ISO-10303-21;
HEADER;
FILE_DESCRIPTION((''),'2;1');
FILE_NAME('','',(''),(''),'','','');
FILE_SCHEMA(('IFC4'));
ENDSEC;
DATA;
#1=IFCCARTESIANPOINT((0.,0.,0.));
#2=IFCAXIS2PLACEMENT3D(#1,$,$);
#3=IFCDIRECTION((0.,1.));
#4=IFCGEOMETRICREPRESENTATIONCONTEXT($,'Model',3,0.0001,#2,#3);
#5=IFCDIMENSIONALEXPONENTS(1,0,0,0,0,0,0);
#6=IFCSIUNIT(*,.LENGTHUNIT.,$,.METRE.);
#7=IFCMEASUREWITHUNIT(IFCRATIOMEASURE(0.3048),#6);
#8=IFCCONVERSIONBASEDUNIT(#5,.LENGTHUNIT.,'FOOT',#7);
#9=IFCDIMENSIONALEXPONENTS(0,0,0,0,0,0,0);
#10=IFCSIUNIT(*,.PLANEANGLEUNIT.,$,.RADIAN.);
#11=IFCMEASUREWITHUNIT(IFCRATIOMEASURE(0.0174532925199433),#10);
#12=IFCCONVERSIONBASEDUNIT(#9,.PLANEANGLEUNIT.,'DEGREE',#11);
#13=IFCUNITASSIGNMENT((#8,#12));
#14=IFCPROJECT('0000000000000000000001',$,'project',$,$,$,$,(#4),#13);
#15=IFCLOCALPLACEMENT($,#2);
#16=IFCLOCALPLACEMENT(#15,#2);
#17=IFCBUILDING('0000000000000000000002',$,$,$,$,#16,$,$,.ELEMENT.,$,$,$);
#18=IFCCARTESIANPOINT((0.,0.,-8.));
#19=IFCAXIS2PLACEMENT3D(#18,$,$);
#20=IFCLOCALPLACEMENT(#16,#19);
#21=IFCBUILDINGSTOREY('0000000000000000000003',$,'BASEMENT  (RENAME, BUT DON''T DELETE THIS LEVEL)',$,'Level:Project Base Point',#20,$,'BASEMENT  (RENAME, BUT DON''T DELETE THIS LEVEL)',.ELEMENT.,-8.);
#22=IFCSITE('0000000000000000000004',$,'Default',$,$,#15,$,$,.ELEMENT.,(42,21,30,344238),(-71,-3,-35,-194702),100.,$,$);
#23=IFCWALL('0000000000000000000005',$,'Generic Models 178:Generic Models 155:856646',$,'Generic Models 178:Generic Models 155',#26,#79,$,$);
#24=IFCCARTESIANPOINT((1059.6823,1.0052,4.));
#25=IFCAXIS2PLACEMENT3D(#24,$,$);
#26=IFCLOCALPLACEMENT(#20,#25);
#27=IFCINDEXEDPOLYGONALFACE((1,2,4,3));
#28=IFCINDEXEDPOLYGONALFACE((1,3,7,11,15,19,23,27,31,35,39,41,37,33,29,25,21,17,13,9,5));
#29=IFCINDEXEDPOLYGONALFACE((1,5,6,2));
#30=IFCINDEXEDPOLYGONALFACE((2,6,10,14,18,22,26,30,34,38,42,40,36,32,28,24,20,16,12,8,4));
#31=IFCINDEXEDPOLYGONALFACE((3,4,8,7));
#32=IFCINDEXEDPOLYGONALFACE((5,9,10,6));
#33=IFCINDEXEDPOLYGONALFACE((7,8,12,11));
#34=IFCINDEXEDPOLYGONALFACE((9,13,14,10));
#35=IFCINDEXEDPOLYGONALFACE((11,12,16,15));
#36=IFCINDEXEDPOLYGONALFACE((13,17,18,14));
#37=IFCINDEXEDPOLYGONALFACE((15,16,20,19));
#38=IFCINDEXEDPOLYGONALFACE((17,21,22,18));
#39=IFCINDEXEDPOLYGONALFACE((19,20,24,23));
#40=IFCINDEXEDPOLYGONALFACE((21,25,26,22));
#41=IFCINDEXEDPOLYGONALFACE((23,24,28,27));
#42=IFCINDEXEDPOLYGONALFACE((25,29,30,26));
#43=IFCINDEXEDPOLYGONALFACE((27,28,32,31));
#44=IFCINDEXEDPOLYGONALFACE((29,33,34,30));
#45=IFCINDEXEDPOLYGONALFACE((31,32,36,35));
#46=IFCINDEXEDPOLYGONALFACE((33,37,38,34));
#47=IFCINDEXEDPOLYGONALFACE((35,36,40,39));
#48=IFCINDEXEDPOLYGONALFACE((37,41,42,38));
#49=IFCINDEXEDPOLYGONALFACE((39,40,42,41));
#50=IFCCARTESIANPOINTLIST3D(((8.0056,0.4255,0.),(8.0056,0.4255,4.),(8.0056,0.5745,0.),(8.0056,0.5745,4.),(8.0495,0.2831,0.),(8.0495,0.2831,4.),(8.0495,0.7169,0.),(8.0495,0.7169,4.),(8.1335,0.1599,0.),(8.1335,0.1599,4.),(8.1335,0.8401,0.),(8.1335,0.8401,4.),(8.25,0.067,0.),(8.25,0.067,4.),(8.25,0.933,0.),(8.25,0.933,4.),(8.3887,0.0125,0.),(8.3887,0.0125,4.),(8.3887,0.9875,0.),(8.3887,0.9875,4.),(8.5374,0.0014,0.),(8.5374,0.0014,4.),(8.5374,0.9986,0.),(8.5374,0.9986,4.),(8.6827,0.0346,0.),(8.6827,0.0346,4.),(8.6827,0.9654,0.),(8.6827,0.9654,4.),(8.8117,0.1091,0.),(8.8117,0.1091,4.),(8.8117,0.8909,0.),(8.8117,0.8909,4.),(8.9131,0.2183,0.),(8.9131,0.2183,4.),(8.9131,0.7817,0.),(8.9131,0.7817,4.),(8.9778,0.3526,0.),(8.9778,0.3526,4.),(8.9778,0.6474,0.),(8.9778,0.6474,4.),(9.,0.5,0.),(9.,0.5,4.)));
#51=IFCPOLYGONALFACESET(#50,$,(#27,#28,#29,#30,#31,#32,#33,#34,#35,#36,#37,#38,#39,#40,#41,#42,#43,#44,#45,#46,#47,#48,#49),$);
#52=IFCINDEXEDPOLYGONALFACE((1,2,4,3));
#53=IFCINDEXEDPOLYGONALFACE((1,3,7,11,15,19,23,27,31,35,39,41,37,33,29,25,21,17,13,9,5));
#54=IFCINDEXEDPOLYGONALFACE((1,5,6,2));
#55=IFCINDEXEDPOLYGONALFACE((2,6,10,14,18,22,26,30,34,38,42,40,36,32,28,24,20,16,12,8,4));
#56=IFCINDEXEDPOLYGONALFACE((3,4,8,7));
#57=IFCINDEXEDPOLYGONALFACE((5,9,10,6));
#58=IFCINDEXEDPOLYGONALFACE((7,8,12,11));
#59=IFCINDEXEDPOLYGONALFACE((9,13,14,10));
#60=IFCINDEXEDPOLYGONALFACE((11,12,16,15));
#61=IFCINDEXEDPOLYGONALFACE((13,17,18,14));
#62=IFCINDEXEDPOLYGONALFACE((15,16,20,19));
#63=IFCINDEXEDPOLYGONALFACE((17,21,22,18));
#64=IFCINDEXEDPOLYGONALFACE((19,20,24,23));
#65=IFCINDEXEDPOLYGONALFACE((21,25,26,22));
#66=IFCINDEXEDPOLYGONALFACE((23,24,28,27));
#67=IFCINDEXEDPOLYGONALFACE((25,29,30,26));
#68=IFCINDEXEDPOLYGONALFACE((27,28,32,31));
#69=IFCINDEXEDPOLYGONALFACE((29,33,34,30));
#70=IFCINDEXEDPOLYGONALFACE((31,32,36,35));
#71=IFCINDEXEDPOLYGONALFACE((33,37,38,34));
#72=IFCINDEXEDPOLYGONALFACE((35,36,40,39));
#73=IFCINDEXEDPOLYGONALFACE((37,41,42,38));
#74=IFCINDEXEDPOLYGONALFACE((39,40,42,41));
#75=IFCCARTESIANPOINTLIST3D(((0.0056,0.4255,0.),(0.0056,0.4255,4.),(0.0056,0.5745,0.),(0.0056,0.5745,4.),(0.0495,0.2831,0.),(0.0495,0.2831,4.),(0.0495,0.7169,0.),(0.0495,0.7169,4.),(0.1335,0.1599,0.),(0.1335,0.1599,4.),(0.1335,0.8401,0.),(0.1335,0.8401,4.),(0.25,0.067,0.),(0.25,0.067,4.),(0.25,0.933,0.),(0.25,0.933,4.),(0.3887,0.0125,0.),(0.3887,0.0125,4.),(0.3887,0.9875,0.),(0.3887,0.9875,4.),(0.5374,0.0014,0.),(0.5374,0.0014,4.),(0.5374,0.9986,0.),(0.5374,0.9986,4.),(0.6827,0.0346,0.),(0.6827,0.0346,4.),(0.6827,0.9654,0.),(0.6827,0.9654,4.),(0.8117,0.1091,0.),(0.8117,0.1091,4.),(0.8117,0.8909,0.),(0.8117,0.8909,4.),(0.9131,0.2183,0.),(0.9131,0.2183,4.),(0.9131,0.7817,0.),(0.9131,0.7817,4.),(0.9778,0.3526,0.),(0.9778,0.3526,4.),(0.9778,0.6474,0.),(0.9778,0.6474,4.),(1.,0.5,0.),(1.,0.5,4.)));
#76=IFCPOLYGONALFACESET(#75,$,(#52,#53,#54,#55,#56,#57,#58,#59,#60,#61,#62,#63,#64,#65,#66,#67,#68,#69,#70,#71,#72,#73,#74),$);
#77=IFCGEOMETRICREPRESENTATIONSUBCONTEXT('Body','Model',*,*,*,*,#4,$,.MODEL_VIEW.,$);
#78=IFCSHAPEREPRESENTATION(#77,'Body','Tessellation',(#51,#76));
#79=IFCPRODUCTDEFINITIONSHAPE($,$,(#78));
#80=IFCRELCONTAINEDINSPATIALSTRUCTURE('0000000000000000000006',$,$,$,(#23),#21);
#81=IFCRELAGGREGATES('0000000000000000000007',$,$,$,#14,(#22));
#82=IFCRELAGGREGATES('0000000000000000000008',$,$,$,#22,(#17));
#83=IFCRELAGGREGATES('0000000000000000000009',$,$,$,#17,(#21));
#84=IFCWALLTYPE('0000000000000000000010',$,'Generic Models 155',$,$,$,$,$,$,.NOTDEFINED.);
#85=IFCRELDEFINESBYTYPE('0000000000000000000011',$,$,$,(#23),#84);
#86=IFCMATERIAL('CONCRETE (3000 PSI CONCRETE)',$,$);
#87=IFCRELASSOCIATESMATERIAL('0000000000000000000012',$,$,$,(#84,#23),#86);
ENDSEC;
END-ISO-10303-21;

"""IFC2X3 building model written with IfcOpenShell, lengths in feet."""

from ifc_helpers import new_model, entity, si_unit, converted_unit, direction, frame, frame_2d, origin, place, context, subcontext, project, spatial, circle, extrude, material, type_object, element, save


model = new_model("IFC2X3")

# Units and contexts
model_context = context("Model", 3, precision=0.0001, world=origin(), true_north=direction((0.0, 1.0)))
body_context = subcontext(model_context, "Body", "Model", "MODEL_VIEW")
ifc_project = project(units=[converted_unit("LENGTHUNIT", "FOOT", entity("IfcRatioMeasure", 0.3048), si_unit("LENGTHUNIT", "METRE"), dimensions=[1, 0, 0, 0, 0, 0, 0]), converted_unit("PLANEANGLEUNIT", "DEGREE", entity("IfcRatioMeasure", 0.0174532925199433), si_unit("PLANEANGLEUNIT", "RADIAN"), dimensions=[0, 0, 0, 0, 0, 0, 0])], contexts=[model_context])

# Site, building, storey
site_placement = place(None, origin())
site = spatial("IfcSite", under=ifc_project, at=site_placement, Name="Default", CompositionType="ELEMENT", RefLatitude=(42, 21, 30, 344238), RefLongitude=(-71, -3, -35, -194702), RefElevation=100.0)
building_placement = place(site_placement, origin())
building = spatial("IfcBuilding", under=site, at=building_placement, CompositionType="ELEMENT")
storey_placement = place(building_placement, frame((0.0, 0.0, -8.0)))
storey = spatial("IfcBuildingStorey", under=building, at=storey_placement, Name="BASEMENT  (RENAME, BUT DON'T DELETE THIS LEVEL)", ObjectType="Level:Project Base Point", LongName="BASEMENT  (RENAME, BUT DON'T DELETE THIS LEVEL)", CompositionType="ELEMENT", Elevation=-8.0)

# Wall
ifc_material_1 = material(Name="CONCRETE (3000 PSI CONCRETE)")
wall_type_1 = type_object("IfcWallType", Name="Generic Models 155", PredefinedType="NOTDEFINED", material=ifc_material_1)
wall_1_placement = place(storey_placement, frame((1059.6823, 1.0052, 4.0)))
element("IfcWall", 1, at=wall_1_placement, inside=storey, type_object=wall_type_1, material=ifc_material_1, Name="Generic Models 178:Generic Models 155:856646", ObjectType="Generic Models 178:Generic Models 155", context=body_context, shape_type="SweptSolid", body=[
    extrude(circle(Radius=0.5, at=frame_2d((0.0, 0.0), x_axis=(1.0, 0.0))), frame((8.5, 0.5, 0.0)), (0.0, 0.0, 1.0), 4.0),
    extrude(circle(Radius=0.5, at=frame_2d((0.0, 0.0), x_axis=(1.0, 0.0))), frame((0.5, 0.5, 0.0)), (0.0, 0.0, 1.0), 4.0),
])

save(model, "model.ifc")
